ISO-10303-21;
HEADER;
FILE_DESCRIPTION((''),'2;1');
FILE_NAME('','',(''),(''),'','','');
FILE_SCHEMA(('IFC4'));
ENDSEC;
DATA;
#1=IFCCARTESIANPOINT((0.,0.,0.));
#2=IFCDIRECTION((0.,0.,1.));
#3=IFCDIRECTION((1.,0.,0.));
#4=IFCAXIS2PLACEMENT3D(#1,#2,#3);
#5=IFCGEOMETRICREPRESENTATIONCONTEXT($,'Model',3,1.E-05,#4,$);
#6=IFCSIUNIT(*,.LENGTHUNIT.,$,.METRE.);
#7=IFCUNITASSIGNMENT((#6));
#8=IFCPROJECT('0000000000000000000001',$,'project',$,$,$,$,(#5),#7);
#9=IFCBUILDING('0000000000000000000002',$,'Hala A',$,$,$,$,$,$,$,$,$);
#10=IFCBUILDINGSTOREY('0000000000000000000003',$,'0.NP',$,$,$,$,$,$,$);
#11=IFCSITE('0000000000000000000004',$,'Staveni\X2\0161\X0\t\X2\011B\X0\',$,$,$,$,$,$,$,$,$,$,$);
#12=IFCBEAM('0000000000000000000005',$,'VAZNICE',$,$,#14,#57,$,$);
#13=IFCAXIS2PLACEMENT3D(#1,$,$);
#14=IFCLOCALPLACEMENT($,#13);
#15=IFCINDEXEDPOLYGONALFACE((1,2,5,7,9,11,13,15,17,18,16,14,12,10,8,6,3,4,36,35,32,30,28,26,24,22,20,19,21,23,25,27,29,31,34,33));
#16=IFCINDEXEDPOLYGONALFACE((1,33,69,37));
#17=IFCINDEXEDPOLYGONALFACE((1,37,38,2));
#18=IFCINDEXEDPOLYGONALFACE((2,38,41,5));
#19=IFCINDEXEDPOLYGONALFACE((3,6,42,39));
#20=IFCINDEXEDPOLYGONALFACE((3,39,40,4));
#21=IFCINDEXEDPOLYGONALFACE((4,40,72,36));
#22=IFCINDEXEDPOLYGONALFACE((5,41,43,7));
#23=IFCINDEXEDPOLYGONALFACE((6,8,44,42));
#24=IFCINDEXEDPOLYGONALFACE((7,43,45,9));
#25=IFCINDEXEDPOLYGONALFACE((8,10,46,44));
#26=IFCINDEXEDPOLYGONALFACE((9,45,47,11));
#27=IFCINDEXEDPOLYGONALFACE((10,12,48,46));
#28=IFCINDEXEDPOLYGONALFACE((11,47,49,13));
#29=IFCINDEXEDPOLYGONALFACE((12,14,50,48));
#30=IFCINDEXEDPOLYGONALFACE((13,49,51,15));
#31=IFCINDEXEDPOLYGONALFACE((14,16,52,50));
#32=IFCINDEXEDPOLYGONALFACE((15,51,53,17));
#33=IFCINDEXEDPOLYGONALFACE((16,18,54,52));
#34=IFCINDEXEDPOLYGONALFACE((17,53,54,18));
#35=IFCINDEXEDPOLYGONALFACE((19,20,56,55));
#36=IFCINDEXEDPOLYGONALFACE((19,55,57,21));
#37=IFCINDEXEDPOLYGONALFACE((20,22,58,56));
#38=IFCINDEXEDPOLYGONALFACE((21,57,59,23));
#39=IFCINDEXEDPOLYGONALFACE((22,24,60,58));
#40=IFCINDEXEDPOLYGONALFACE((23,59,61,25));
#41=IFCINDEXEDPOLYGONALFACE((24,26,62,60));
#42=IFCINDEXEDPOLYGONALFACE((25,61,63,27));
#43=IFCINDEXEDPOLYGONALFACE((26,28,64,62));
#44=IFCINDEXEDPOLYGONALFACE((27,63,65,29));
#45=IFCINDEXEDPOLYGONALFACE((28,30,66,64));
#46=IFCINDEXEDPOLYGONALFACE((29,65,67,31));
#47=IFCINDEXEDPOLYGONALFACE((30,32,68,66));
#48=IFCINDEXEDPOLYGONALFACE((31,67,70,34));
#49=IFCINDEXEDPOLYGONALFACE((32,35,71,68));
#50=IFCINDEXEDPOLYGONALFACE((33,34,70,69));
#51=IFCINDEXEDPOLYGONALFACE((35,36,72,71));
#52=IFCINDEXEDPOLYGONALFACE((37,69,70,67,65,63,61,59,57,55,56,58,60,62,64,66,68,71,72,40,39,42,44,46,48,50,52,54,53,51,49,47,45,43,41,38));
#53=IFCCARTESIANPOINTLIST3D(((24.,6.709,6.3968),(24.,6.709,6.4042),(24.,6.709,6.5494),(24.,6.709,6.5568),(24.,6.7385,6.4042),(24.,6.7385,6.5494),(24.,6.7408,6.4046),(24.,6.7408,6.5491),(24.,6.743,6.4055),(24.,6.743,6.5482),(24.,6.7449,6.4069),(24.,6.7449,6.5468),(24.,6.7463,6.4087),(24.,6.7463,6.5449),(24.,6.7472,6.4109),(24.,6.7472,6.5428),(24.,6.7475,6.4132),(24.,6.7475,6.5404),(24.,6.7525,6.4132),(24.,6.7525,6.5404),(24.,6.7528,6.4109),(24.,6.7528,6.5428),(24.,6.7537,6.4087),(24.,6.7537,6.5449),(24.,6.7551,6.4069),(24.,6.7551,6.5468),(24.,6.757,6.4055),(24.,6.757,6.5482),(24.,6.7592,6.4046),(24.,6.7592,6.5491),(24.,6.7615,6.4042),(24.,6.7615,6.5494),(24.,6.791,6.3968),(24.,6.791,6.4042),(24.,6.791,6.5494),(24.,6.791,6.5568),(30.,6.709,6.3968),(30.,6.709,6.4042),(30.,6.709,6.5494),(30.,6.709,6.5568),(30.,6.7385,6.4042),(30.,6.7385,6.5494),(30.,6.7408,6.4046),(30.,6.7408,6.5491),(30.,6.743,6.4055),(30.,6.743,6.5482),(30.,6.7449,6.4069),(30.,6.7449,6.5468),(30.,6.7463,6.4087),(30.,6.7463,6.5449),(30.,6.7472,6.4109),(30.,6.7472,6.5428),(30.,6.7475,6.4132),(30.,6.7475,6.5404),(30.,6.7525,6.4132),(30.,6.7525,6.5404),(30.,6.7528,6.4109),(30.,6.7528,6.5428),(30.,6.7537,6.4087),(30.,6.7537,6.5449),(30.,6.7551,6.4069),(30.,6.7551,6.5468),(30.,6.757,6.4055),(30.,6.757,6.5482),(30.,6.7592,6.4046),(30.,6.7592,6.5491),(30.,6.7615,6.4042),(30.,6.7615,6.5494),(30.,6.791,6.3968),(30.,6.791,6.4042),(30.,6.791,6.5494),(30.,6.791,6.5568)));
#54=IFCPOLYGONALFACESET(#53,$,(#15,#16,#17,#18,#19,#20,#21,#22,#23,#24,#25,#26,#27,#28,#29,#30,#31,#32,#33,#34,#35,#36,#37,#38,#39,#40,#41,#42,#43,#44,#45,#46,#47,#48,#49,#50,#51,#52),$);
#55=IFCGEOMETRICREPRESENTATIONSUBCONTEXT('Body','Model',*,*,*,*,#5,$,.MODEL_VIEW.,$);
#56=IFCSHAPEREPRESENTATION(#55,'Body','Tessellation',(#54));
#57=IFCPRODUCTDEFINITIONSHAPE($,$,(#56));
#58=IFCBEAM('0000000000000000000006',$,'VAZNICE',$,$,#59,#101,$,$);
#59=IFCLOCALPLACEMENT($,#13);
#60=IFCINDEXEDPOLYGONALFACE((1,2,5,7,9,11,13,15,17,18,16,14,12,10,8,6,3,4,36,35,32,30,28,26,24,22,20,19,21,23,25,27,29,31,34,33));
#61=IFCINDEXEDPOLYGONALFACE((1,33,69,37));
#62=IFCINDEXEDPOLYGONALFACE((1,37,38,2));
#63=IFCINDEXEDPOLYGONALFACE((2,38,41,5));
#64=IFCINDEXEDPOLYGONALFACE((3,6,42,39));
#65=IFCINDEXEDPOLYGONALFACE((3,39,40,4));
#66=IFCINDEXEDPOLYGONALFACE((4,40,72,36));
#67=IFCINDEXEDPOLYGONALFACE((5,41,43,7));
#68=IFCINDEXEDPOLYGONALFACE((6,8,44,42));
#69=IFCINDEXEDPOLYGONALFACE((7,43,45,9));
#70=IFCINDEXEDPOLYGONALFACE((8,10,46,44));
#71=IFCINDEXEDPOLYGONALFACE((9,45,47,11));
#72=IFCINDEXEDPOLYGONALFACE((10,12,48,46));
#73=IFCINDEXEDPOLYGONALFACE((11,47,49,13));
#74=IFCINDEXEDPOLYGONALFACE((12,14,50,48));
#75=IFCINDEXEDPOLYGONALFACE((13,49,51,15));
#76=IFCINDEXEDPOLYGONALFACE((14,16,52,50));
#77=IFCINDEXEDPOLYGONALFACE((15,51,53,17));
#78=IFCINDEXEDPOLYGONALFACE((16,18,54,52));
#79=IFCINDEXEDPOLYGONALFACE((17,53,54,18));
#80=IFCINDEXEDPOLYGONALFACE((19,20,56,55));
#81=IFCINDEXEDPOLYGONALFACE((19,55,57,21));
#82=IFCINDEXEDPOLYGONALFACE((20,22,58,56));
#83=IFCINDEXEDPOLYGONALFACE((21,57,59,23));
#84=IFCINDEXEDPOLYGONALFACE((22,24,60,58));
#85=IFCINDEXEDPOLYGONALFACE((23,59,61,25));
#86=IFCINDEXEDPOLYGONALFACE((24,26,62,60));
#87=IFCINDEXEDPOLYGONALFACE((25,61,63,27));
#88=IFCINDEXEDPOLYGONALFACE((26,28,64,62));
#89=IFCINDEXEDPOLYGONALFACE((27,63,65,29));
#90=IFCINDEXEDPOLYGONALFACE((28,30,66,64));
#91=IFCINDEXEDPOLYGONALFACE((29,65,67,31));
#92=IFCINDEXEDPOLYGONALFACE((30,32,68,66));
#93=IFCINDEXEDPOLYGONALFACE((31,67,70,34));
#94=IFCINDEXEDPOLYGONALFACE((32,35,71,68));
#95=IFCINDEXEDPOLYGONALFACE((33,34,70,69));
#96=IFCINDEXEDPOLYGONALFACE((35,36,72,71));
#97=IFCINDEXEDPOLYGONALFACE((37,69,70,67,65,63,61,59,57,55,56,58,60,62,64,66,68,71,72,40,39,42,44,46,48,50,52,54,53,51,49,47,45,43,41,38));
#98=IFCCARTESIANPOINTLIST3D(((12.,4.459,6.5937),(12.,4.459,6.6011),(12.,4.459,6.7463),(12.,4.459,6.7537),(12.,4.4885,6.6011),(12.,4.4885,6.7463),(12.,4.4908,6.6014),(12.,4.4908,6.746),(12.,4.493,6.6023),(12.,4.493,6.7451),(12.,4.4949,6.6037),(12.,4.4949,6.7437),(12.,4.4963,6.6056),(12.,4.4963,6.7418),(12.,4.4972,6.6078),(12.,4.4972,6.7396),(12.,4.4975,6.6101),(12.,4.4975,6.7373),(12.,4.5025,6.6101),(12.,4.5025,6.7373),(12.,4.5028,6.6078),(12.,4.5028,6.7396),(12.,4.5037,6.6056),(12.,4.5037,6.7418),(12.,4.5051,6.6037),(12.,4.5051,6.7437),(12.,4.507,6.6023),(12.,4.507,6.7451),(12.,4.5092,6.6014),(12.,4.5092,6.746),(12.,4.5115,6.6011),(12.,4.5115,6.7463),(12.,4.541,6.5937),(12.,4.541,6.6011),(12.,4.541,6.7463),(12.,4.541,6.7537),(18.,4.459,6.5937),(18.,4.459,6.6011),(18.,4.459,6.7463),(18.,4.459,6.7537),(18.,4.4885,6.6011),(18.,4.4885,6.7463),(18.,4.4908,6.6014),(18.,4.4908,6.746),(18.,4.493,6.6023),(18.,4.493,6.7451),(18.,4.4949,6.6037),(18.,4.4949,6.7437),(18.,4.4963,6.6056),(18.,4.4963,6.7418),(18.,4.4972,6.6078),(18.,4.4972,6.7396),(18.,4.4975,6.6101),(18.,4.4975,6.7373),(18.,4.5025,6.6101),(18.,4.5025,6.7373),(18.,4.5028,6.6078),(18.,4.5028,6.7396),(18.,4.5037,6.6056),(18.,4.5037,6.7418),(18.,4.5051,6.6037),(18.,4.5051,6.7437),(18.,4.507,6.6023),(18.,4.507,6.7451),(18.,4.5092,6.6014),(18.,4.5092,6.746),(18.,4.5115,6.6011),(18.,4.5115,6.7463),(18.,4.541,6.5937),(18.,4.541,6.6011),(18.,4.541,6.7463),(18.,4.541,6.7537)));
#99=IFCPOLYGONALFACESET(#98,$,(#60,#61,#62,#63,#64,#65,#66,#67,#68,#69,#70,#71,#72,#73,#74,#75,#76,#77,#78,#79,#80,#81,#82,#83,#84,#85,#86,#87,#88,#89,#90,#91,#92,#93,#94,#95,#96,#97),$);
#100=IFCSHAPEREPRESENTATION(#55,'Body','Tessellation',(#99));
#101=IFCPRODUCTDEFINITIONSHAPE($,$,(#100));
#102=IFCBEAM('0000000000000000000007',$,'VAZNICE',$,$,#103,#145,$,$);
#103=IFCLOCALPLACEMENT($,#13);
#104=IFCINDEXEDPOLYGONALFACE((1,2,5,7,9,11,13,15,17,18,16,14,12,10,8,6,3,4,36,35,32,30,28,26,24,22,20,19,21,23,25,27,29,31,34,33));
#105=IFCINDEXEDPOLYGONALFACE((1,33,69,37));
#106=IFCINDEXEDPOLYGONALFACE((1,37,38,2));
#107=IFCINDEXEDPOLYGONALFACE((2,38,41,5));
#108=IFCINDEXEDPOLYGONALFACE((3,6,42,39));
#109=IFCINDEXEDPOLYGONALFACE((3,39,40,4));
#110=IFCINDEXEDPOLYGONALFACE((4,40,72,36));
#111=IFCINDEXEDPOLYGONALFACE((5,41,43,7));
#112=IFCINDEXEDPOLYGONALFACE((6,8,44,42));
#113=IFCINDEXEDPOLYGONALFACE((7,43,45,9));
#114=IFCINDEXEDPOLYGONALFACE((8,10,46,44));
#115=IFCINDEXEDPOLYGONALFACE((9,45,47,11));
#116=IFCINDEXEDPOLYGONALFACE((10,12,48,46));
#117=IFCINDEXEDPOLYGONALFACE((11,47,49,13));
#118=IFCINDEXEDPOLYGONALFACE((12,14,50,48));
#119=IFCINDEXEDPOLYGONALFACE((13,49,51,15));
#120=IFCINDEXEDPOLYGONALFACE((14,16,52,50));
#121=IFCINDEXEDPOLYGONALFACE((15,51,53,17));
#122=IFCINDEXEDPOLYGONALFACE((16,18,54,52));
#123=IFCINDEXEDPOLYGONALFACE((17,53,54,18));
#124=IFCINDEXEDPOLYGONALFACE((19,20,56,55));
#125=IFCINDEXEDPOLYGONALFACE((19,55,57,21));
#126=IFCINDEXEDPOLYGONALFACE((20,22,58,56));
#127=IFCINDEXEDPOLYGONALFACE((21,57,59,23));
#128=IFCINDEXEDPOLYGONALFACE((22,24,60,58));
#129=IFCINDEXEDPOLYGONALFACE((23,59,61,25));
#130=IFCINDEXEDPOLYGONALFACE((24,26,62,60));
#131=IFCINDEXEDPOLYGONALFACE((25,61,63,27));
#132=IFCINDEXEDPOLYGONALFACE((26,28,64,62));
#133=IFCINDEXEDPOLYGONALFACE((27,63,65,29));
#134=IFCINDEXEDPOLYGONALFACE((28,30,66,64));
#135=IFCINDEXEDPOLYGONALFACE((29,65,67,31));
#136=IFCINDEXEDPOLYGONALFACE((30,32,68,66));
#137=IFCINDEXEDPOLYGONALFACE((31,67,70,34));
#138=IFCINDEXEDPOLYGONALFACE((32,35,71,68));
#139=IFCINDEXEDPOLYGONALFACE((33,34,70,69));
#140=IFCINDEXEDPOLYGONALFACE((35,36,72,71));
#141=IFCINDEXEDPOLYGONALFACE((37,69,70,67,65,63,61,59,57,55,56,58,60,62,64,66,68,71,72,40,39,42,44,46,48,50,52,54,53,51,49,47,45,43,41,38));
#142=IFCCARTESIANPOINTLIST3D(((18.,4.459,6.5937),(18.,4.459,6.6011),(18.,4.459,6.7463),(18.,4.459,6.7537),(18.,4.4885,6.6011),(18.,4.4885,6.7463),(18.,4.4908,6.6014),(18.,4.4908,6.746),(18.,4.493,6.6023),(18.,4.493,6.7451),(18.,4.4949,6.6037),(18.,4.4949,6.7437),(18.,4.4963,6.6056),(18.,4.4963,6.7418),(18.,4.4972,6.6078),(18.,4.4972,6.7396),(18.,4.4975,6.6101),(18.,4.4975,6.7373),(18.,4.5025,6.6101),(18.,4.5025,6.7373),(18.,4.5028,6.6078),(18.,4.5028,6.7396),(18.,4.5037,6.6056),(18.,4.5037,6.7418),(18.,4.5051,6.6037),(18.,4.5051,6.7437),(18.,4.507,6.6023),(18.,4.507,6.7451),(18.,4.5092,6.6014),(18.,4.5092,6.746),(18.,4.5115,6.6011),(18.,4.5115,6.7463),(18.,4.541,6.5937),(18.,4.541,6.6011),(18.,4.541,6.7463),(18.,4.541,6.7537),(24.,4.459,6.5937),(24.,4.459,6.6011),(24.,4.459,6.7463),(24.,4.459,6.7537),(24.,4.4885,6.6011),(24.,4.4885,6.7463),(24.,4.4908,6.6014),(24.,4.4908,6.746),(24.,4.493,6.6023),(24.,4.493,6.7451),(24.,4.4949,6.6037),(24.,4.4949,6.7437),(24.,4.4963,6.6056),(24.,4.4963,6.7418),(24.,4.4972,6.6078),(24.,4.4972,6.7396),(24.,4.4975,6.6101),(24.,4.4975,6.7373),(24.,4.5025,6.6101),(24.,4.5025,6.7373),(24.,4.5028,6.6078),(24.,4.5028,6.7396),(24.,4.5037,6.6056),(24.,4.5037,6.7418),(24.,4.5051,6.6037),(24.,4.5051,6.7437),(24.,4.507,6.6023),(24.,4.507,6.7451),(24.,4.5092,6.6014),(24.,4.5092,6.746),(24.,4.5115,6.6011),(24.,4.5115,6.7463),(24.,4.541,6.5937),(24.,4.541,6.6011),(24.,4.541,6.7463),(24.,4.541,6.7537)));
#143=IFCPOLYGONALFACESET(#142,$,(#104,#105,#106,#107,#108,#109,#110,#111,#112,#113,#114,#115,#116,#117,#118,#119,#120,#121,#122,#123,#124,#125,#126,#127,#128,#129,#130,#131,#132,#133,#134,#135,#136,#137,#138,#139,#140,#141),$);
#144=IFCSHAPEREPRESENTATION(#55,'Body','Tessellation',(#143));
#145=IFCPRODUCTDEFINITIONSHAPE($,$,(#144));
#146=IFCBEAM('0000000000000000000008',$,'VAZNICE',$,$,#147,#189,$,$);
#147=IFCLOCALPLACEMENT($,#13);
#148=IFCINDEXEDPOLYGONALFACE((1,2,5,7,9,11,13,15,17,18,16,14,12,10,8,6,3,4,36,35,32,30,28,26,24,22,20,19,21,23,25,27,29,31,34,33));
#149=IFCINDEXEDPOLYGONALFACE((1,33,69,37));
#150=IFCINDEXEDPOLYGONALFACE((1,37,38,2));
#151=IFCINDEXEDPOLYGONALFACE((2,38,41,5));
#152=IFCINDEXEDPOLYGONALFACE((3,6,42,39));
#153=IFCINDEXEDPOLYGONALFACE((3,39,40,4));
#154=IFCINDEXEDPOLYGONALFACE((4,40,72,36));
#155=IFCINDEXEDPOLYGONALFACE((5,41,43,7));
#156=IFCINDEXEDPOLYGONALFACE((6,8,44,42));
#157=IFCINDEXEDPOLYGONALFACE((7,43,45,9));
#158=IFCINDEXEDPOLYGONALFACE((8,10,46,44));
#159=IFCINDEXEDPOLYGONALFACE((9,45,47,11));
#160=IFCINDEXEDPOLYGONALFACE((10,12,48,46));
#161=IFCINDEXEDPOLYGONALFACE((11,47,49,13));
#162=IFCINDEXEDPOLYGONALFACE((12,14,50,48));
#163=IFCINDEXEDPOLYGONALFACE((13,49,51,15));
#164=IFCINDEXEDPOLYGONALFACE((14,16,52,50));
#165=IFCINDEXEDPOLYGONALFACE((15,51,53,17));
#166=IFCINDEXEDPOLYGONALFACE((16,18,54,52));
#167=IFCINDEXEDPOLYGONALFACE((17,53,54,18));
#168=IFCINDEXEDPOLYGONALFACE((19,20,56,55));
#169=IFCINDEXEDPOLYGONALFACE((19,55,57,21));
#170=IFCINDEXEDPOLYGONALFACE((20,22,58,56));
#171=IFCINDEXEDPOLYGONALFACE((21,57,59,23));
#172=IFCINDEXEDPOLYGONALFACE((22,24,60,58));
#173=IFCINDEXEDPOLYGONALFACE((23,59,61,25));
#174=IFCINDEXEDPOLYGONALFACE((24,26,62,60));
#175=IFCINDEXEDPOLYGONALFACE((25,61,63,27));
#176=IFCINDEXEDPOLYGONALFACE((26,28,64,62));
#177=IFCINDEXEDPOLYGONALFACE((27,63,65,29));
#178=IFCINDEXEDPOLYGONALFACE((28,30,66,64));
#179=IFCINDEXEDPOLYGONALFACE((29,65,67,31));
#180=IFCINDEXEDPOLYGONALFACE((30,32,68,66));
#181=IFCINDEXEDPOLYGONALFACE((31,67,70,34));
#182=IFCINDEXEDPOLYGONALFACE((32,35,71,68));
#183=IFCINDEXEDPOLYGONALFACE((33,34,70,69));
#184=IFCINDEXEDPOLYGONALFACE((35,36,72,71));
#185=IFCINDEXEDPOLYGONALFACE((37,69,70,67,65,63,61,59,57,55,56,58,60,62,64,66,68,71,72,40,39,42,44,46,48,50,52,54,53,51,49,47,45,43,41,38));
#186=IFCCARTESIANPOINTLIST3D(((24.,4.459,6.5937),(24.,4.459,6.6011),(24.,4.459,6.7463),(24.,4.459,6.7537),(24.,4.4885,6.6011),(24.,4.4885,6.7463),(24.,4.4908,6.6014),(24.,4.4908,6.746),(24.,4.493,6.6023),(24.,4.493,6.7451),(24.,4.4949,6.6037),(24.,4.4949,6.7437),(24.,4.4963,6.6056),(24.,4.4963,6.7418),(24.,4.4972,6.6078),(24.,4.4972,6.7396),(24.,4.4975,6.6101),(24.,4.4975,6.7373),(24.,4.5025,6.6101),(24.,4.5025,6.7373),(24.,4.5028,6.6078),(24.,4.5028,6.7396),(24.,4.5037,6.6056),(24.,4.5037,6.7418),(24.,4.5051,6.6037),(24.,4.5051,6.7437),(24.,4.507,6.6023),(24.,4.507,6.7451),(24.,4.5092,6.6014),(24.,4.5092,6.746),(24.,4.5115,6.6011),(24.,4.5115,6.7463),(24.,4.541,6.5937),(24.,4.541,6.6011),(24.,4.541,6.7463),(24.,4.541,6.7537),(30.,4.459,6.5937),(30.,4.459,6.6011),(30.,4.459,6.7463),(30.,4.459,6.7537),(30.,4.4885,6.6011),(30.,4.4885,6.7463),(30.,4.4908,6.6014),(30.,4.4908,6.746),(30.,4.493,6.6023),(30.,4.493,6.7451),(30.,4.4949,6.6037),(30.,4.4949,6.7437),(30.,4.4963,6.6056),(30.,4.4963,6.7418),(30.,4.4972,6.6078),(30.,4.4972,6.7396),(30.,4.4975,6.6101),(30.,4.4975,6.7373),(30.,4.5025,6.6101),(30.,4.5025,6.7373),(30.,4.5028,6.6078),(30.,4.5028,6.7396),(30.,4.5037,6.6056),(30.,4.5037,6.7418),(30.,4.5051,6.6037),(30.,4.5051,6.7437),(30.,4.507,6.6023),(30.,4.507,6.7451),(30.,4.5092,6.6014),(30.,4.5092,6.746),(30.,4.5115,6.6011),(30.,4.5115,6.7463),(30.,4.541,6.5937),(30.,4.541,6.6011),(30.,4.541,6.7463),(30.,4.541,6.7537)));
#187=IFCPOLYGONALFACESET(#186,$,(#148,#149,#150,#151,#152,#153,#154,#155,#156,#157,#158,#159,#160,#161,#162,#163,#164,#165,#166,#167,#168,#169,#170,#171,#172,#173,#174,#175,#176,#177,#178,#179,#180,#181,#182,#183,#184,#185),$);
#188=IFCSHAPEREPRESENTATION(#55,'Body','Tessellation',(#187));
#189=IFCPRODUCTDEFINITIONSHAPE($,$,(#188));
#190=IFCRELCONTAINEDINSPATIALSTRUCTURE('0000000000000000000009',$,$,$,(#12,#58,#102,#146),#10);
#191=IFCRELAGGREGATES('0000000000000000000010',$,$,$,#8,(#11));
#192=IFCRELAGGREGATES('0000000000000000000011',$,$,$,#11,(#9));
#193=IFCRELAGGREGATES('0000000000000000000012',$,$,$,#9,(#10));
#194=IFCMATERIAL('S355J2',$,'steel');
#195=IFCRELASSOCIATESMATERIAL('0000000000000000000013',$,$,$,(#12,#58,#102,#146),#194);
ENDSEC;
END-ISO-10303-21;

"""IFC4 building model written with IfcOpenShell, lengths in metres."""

from ifc_helpers import new_model, si_unit, frame, origin_with_axes, place, context, subcontext, project, spatial, i_section, extrude, material, element, save


model = new_model("IFC4")

# Units and contexts
model_context = context("Model", 3, precision=1e-05, world=origin_with_axes())
body_context = subcontext(model_context, "Body", "Model", "MODEL_VIEW")
ifc_project = project(units=[si_unit("LENGTHUNIT", "METRE")], contexts=[model_context])

# Site, building, storey
site = spatial("IfcSite", under=ifc_project, Name="Staveniště")
building = spatial("IfcBuilding", under=site, Name="Hala A")
storey = spatial("IfcBuildingStorey", under=building, Name="0.NP")

# Shared definitions
ifc_material_1 = material(Name="S355J2", Category="steel")

# Beams
for number, where, z_axis, x_axis, name in (
    (1, (24.0, 6.75, 6.4768), (1.0, 0.0, 0.0), (0.0, 1.0, 0.0), "VAZNICE"),
    (2, (12.0, 4.5, 6.6737), (1.0, 0.0, 0.0), (0.0, 1.0, 0.0), "VAZNICE"),
    (3, (18.0, 4.5, 6.6737), (1.0, 0.0, 0.0), (0.0, 1.0, 0.0), "VAZNICE"),
    (4, (24.0, 4.5, 6.6737), (1.0, 0.0, 0.0), (0.0, 1.0, 0.0), "VAZNICE"),
):
    element("IfcBeam", number, at=place(None, frame(where, z_axis=z_axis, x_axis=x_axis)), inside=storey, material=ifc_material_1, Name=name, context=body_context, shape_type="SweptSolid", body=[
        extrude(i_section(OverallWidth=0.082, OverallDepth=0.16, WebThickness=0.005, FlangeThickness=0.0074, FilletRadius=0.009), origin_with_axes(), (0.0, 0.0, 1.0), 6.0),
    ])

save(model, "model.ifc")
